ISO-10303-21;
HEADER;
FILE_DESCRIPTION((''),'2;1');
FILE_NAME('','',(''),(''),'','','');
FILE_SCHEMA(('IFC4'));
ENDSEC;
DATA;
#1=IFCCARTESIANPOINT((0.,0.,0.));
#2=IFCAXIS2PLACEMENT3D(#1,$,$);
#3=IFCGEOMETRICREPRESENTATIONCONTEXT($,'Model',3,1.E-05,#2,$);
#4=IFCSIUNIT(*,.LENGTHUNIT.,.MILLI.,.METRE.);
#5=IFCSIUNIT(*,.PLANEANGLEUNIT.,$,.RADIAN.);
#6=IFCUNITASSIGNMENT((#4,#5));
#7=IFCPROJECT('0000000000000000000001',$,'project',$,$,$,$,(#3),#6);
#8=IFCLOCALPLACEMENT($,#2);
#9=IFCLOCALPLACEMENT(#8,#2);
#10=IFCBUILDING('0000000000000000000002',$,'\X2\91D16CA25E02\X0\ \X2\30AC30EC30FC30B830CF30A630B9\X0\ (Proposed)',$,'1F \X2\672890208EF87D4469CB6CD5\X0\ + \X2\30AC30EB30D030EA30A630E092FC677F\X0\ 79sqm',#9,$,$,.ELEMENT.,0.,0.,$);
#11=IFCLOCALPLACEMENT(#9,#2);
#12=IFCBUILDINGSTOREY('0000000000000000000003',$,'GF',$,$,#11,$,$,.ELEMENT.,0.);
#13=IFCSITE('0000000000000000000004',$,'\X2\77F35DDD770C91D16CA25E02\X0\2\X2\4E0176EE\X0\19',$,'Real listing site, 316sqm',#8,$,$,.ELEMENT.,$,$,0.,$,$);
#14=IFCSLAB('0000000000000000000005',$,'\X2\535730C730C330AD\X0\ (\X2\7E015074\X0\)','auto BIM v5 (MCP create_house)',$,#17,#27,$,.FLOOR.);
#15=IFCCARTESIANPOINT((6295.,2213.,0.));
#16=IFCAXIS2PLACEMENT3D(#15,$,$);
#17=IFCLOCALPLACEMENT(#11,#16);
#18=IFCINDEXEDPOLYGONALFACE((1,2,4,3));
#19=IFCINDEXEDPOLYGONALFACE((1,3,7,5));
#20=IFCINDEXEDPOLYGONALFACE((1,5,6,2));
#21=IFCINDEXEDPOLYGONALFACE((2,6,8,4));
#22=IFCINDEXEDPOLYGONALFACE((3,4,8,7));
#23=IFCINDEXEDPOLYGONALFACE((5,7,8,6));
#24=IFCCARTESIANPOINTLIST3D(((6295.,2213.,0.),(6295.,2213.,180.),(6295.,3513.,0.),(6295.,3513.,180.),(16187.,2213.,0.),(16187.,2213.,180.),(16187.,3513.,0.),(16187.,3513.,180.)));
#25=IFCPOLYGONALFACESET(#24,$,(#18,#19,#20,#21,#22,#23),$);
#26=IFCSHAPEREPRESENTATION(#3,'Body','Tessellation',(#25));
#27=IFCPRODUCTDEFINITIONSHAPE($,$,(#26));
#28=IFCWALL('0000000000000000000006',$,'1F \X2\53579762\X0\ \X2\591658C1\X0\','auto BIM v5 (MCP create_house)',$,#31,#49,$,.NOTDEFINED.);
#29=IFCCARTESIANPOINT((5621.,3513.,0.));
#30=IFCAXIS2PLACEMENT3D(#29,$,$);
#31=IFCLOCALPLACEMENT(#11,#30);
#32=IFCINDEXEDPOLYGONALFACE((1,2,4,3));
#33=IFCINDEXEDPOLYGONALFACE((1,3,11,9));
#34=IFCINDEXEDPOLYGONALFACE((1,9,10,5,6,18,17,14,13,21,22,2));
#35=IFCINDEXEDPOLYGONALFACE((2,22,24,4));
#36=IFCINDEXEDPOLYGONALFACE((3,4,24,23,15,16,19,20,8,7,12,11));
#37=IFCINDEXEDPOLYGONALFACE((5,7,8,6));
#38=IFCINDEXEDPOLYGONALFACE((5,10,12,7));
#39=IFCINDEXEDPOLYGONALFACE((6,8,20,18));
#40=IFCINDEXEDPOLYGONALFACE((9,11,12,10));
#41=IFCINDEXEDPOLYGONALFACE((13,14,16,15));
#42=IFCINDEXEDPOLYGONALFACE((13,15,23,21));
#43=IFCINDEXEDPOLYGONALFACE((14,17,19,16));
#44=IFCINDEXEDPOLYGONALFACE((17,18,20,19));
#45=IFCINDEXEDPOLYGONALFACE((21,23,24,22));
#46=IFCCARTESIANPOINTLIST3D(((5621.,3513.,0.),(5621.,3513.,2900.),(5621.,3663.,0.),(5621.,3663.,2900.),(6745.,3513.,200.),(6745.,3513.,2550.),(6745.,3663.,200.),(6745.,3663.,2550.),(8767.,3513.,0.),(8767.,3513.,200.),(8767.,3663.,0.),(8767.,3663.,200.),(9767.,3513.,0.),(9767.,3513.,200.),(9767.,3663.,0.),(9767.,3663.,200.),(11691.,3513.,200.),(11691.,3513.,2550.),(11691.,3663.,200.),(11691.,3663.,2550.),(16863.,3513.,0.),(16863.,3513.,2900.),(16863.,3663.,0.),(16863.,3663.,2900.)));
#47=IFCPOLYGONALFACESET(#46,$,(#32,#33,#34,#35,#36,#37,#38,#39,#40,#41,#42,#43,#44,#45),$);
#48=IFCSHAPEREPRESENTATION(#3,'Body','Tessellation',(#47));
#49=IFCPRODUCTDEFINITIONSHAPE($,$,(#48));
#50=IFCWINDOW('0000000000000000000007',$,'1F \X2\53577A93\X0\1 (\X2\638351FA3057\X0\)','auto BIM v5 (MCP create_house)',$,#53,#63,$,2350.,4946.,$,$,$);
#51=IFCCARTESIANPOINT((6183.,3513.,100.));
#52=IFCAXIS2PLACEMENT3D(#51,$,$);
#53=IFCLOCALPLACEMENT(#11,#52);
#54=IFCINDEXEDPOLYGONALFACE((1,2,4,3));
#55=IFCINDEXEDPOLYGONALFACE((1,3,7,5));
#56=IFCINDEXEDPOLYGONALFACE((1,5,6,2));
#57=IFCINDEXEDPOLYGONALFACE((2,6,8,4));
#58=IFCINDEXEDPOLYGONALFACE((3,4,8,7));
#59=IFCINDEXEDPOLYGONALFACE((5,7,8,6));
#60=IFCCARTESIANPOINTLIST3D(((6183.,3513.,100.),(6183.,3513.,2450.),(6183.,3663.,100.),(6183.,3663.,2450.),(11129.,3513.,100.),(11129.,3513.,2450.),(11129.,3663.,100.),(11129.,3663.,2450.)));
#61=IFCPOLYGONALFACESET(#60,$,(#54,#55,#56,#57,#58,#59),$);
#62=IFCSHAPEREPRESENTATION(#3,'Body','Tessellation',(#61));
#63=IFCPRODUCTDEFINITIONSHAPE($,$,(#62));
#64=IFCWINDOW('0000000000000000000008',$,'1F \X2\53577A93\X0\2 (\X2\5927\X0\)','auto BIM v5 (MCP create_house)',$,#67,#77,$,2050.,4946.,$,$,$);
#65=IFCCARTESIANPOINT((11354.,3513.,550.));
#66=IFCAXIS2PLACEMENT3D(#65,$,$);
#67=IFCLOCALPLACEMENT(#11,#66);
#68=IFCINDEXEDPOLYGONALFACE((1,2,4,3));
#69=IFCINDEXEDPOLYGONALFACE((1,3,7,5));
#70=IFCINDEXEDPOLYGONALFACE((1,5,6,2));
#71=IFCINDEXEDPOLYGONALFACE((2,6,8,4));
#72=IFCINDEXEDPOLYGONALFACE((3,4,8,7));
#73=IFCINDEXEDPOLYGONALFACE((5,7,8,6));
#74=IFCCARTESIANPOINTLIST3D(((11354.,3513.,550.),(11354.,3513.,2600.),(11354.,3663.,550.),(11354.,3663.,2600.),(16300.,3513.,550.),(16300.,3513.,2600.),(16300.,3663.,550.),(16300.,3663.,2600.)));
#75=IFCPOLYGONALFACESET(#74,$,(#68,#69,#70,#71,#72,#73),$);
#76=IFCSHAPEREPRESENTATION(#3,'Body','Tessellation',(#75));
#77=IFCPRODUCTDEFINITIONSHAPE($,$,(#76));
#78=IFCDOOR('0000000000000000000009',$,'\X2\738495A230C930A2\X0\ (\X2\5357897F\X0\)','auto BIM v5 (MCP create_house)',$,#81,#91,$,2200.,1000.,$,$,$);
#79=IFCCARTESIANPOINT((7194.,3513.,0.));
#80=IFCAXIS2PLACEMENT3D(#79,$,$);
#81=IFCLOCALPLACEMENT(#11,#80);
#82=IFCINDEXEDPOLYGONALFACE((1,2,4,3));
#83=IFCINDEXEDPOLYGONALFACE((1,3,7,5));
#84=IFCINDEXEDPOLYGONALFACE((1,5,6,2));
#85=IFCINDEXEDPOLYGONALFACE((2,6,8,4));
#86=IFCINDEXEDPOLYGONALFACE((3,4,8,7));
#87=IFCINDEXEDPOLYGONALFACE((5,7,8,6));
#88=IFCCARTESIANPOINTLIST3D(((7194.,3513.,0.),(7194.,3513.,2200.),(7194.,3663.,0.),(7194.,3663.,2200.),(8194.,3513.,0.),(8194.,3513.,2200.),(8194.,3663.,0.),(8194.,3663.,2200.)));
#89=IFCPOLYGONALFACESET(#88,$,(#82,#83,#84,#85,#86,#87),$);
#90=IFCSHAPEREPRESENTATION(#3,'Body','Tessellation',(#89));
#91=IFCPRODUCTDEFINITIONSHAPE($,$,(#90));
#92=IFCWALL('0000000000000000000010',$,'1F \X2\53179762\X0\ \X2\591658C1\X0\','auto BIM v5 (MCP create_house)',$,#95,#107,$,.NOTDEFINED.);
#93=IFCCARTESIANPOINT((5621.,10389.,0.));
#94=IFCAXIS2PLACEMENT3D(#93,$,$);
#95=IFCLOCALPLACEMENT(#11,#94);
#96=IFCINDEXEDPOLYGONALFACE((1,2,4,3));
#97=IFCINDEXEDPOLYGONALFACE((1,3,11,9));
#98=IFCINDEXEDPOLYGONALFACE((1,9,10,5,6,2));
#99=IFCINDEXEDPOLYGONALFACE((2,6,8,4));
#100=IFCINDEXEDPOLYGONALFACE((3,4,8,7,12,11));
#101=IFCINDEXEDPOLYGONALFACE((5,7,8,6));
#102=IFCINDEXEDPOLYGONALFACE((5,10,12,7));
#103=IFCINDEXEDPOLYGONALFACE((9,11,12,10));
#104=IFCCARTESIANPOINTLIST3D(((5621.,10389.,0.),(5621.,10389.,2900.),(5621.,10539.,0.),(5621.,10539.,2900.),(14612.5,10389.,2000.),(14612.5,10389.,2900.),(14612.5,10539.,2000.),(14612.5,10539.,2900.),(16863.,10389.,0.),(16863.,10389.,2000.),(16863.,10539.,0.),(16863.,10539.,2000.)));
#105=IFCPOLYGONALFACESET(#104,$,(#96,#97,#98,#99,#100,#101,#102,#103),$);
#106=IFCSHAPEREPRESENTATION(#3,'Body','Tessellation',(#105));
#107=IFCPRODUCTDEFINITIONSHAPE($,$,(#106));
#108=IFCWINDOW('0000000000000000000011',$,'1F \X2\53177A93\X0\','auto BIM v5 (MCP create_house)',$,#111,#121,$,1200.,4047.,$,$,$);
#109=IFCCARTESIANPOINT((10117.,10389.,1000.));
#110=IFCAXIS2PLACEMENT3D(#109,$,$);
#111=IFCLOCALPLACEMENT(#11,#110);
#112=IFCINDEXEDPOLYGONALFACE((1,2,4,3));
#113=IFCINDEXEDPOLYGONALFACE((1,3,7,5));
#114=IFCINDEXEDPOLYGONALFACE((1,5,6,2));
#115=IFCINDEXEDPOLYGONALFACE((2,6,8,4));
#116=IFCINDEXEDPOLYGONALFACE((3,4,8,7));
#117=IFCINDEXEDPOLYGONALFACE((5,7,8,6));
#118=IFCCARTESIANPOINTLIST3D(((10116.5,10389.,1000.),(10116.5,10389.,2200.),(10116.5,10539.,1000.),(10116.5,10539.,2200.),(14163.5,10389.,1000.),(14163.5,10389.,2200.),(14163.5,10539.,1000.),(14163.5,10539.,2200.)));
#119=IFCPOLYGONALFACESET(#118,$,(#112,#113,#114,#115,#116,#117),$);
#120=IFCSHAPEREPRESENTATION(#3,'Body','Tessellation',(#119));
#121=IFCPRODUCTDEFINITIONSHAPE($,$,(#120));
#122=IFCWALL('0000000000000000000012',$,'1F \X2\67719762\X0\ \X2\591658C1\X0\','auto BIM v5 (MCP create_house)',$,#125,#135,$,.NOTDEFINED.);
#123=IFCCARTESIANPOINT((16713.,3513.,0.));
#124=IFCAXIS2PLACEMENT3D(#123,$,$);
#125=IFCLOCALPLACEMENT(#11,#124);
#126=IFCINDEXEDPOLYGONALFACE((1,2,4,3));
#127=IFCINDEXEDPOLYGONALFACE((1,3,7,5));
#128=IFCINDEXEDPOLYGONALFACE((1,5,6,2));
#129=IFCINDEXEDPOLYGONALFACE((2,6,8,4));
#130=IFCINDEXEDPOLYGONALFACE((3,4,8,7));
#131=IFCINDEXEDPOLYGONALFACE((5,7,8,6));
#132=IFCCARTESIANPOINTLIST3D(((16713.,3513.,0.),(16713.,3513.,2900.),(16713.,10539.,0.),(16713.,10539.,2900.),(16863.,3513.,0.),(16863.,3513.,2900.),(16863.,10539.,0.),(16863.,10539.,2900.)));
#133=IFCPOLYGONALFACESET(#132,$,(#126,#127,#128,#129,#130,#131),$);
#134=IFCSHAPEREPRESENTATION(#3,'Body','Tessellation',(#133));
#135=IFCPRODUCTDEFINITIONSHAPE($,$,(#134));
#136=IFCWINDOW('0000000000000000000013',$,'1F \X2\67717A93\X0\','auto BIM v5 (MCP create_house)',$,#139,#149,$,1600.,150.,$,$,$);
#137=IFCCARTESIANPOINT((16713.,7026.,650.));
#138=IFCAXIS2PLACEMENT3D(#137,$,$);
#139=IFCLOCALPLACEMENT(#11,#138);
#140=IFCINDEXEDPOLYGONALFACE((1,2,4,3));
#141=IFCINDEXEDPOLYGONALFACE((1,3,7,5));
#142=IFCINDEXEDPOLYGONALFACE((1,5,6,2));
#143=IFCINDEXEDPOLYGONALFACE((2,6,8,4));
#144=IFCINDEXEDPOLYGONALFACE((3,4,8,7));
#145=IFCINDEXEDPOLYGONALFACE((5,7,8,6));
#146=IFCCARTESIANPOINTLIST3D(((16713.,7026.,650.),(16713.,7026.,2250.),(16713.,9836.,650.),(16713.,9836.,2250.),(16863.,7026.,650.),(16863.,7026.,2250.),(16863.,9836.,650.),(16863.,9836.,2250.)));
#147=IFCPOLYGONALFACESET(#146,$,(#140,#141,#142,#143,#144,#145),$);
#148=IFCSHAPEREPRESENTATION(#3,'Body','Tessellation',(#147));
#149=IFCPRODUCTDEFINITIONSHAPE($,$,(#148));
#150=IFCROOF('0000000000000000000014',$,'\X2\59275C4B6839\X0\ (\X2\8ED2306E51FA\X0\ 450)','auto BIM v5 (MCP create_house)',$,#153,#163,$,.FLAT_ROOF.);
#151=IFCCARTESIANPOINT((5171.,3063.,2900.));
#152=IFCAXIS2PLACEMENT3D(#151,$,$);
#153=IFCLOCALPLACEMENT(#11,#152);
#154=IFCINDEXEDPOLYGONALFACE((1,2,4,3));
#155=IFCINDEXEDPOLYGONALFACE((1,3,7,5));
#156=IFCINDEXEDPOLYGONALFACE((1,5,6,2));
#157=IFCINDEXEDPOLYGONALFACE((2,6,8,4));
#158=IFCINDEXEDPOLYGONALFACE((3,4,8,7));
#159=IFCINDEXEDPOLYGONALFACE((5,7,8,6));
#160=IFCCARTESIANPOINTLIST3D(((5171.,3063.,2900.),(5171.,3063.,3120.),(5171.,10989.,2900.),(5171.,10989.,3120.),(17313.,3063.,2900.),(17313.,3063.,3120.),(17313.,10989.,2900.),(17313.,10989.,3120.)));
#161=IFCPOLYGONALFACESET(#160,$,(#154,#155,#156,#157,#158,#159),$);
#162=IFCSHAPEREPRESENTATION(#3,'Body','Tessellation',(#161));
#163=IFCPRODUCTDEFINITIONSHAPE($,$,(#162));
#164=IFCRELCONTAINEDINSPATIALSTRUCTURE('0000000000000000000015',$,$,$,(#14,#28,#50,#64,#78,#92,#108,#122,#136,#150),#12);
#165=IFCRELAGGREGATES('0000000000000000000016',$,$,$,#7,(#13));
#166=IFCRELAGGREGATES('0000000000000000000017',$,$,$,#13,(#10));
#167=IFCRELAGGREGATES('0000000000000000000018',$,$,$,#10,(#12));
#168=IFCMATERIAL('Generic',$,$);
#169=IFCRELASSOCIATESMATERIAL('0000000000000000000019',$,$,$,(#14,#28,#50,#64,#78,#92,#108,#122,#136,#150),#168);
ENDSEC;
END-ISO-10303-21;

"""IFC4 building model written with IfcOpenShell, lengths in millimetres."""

from ifc_helpers import new_model, si_unit, frame, frame_2d, origin, place, context, project, spatial, rectangle, extrude, material, element, fill, save


model = new_model("IFC4")

# Units and contexts
model_context = context("Model", 3, precision=1e-05, world=origin())
ifc_project = project(units=[si_unit("LENGTHUNIT", "METRE", prefix="MILLI"), si_unit("PLANEANGLEUNIT", "RADIAN")], contexts=[model_context])

# Site, building, storey
site_placement = place(None, origin())
site = spatial("IfcSite", under=ifc_project, at=site_placement, Name="石川県金沢市2丁目19", ObjectType="Real listing site, 316sqm", CompositionType="ELEMENT", RefElevation=0.0)
building_placement = place(site_placement, origin())
building = spatial("IfcBuilding", under=site, at=building_placement, Name="金沢市 ガレージハウス (Proposed)", ObjectType="1F 木造軸組構法 + ガルバリウム鋼板 79sqm", CompositionType="ELEMENT", ElevationOfRefHeight=0.0, ElevationOfTerrain=0.0)
storey_placement = place(building_placement, origin())
storey = spatial("IfcBuildingStorey", under=building, at=storey_placement, Name="GF", CompositionType="ELEMENT", Elevation=0.0)

# Slab
ifc_material = material(Name="Generic")
slab_1_placement = place(storey_placement, frame((6295.0, 2213.0, 0.0)))
element("IfcSlab", 1, at=slab_1_placement, inside=storey, material=ifc_material, Name="南デッキ (縁側)", Description="auto BIM v5 (MCP create_house)", PredefinedType="FLOOR", context=model_context, shape_type="SweptSolid", body=[
    extrude(rectangle(XDim=9892.0, YDim=1300.0, at=frame_2d((4946.0, 650.0))), frame((6295.0, 2213.0, 0.0)), (0.0, 0.0, 1.0), 180.0),
])

# Wall, openings, windows, door
wall_1_placement = place(storey_placement, frame((5621.0, 3513.0, 0.0)))
wall_1 = element("IfcWall", 2, at=wall_1_placement, inside=storey, material=ifc_material, Name="1F 南面 外壁", Description="auto BIM v5 (MCP create_house)", PredefinedType="NOTDEFINED", context=model_context, shape_type="SweptSolid", body=[
    extrude(rectangle(XDim=11242.0, YDim=150.0, at=frame_2d((5621.0, 75.0))), frame((5621.0, 3513.0, 0.0)), (0.0, 0.0, 1.0), 2900.0),
])
opening_1_placement = place(storey_placement, frame((6183.0, 3513.0, 100.0)))
opening_1 = element("IfcOpeningElement", 3, at=opening_1_placement, cuts=wall_1, PredefinedType="NOTDEFINED", context=model_context, shape_type="SweptSolid", body=[
    extrude(rectangle(XDim=4946.0, YDim=150.0, at=frame_2d((2473.0, 75.0))), frame((6183.0, 3513.0, 100.0)), (0.0, 0.0, 1.0), 2350.0),
])
opening_2_placement = place(storey_placement, frame((11354.0, 3513.0, 550.0)))
opening_2 = element("IfcOpeningElement", 4, at=opening_2_placement, cuts=wall_1, PredefinedType="NOTDEFINED", context=model_context, shape_type="SweptSolid", body=[
    extrude(rectangle(XDim=4946.0, YDim=150.0, at=frame_2d((2473.0, 75.0))), frame((11354.0, 3513.0, 550.0)), (0.0, 0.0, 1.0), 2050.0),
])
opening_3_placement = place(storey_placement, frame((7194.0, 3513.0, 0.0)))
opening_3 = element("IfcOpeningElement", 5, at=opening_3_placement, cuts=wall_1, PredefinedType="NOTDEFINED", context=model_context, shape_type="SweptSolid", body=[
    extrude(rectangle(XDim=1000.0, YDim=150.0, at=frame_2d((500.0, 75.0))), frame((7194.0, 3513.0, 0.0)), (0.0, 0.0, 1.0), 2200.0),
])
window_1_placement = place(storey_placement, frame((6183.0, 3513.0, 100.0)))
window_1 = element("IfcWindow", 6, at=window_1_placement, inside=storey, material=ifc_material, Name="1F 南窓1 (掃出し)", Description="auto BIM v5 (MCP create_house)", OverallHeight=2350.0, OverallWidth=4946.0, context=model_context, shape_type="SweptSolid", body=[
    extrude(rectangle(XDim=4946.0, YDim=150.0, at=frame_2d((2473.0, 75.0))), frame((6183.0, 3513.0, 100.0)), (0.0, 0.0, 1.0), 2350.0),
])
fill(opening_1, window_1)
window_2_placement = place(storey_placement, frame((11354.0, 3513.0, 550.0)))
window_2 = element("IfcWindow", 7, at=window_2_placement, inside=storey, material=ifc_material, Name="1F 南窓2 (大)", Description="auto BIM v5 (MCP create_house)", OverallHeight=2050.0, OverallWidth=4946.0, context=model_context, shape_type="SweptSolid", body=[
    extrude(rectangle(XDim=4946.0, YDim=150.0, at=frame_2d((2473.0, 75.0))), frame((11354.0, 3513.0, 550.0)), (0.0, 0.0, 1.0), 2050.0),
])
fill(opening_2, window_2)
door_placement = place(storey_placement, frame((7194.0, 3513.0, 0.0)))
door = element("IfcDoor", 8, at=door_placement, inside=storey, material=ifc_material, Name="玄関ドア (南西)", Description="auto BIM v5 (MCP create_house)", OverallHeight=2200.0, OverallWidth=1000.0, context=model_context, shape_type="SweptSolid", body=[
    extrude(rectangle(XDim=1000.0, YDim=150.0, at=frame_2d((500.0, 75.0))), frame((7194.0, 3513.0, 0.0)), (0.0, 0.0, 1.0), 2200.0),
])
fill(opening_3, door)

# Walls, openings, windows
wall_2_placement = place(storey_placement, frame((5621.0, 10389.0, 0.0)))
wall_2 = element("IfcWall", 9, at=wall_2_placement, inside=storey, material=ifc_material, Name="1F 北面 外壁", Description="auto BIM v5 (MCP create_house)", PredefinedType="NOTDEFINED", context=model_context, shape_type="SweptSolid", body=[
    extrude(rectangle(XDim=11242.0, YDim=150.0, at=frame_2d((5621.0, 75.0))), frame((5621.0, 10389.0, 0.0)), (0.0, 0.0, 1.0), 2900.0),
])
opening_4_placement = place(storey_placement, frame((10117.0, 10389.0, 1000.0)))
opening_4 = element("IfcOpeningElement", 10, at=opening_4_placement, cuts=wall_2, PredefinedType="NOTDEFINED", context=model_context, shape_type="SweptSolid", body=[
    extrude(rectangle(XDim=4047.0, YDim=150.0, at=frame_2d((2023.0, 75.0))), frame((10117.0, 10389.0, 1000.0)), (0.0, 0.0, 1.0), 1200.0),
])
window_3_placement = place(storey_placement, frame((10117.0, 10389.0, 1000.0)))
window_3 = element("IfcWindow", 11, at=window_3_placement, inside=storey, material=ifc_material, Name="1F 北窓", Description="auto BIM v5 (MCP create_house)", OverallHeight=1200.0, OverallWidth=4047.0, context=model_context, shape_type="SweptSolid", body=[
    extrude(rectangle(XDim=4047.0, YDim=150.0, at=frame_2d((2023.0, 75.0))), frame((10117.0, 10389.0, 1000.0)), (0.0, 0.0, 1.0), 1200.0),
])
fill(opening_4, window_3)
wall_3_placement = place(storey_placement, frame((16713.0, 3513.0, 0.0)))
wall_3 = element("IfcWall", 12, at=wall_3_placement, inside=storey, material=ifc_material, Name="1F 東面 外壁", Description="auto BIM v5 (MCP create_house)", PredefinedType="NOTDEFINED", context=model_context, shape_type="SweptSolid", body=[
    extrude(rectangle(XDim=150.0, YDim=7026.0, at=frame_2d((75.0, 3513.0))), frame((16713.0, 3513.0, 0.0)), (0.0, 0.0, 1.0), 2900.0),
])
opening_5_placement = place(storey_placement, frame((16713.0, 7026.0, 650.0)))
opening_5 = element("IfcOpeningElement", 13, at=opening_5_placement, cuts=wall_3, PredefinedType="NOTDEFINED", context=model_context, shape_type="SweptSolid", body=[
    extrude(rectangle(XDim=150.0, YDim=2810.0, at=frame_2d((75.0, 1405.0))), frame((16713.0, 7026.0, 650.0)), (0.0, 0.0, 1.0), 1600.0),
])
window_4_placement = place(storey_placement, frame((16713.0, 7026.0, 650.0)))
window_4 = element("IfcWindow", 14, at=window_4_placement, inside=storey, material=ifc_material, Name="1F 東窓", Description="auto BIM v5 (MCP create_house)", OverallHeight=1600.0, OverallWidth=150.0, context=model_context, shape_type="SweptSolid", body=[
    extrude(rectangle(XDim=150.0, YDim=2810.0, at=frame_2d((75.0, 1405.0))), frame((16713.0, 7026.0, 650.0)), (0.0, 0.0, 1.0), 1600.0),
])
fill(opening_5, window_4)

# Roof
roof_placement = place(storey_placement, frame((5171.0, 3063.0, 2900.0)))
element("IfcRoof", 15, at=roof_placement, inside=storey, material=ifc_material, Name="大屋根 (軒の出 450)", Description="auto BIM v5 (MCP create_house)", PredefinedType="FLAT_ROOF", context=model_context, shape_type="SweptSolid", body=[
    extrude(rectangle(XDim=12142.0, YDim=7926.0, at=frame_2d((6071.0, 3963.0))), frame((5171.0, 3063.0, 2900.0)), (0.0, 0.0, 1.0), 220.0),
])

save(model, "model.ifc")
